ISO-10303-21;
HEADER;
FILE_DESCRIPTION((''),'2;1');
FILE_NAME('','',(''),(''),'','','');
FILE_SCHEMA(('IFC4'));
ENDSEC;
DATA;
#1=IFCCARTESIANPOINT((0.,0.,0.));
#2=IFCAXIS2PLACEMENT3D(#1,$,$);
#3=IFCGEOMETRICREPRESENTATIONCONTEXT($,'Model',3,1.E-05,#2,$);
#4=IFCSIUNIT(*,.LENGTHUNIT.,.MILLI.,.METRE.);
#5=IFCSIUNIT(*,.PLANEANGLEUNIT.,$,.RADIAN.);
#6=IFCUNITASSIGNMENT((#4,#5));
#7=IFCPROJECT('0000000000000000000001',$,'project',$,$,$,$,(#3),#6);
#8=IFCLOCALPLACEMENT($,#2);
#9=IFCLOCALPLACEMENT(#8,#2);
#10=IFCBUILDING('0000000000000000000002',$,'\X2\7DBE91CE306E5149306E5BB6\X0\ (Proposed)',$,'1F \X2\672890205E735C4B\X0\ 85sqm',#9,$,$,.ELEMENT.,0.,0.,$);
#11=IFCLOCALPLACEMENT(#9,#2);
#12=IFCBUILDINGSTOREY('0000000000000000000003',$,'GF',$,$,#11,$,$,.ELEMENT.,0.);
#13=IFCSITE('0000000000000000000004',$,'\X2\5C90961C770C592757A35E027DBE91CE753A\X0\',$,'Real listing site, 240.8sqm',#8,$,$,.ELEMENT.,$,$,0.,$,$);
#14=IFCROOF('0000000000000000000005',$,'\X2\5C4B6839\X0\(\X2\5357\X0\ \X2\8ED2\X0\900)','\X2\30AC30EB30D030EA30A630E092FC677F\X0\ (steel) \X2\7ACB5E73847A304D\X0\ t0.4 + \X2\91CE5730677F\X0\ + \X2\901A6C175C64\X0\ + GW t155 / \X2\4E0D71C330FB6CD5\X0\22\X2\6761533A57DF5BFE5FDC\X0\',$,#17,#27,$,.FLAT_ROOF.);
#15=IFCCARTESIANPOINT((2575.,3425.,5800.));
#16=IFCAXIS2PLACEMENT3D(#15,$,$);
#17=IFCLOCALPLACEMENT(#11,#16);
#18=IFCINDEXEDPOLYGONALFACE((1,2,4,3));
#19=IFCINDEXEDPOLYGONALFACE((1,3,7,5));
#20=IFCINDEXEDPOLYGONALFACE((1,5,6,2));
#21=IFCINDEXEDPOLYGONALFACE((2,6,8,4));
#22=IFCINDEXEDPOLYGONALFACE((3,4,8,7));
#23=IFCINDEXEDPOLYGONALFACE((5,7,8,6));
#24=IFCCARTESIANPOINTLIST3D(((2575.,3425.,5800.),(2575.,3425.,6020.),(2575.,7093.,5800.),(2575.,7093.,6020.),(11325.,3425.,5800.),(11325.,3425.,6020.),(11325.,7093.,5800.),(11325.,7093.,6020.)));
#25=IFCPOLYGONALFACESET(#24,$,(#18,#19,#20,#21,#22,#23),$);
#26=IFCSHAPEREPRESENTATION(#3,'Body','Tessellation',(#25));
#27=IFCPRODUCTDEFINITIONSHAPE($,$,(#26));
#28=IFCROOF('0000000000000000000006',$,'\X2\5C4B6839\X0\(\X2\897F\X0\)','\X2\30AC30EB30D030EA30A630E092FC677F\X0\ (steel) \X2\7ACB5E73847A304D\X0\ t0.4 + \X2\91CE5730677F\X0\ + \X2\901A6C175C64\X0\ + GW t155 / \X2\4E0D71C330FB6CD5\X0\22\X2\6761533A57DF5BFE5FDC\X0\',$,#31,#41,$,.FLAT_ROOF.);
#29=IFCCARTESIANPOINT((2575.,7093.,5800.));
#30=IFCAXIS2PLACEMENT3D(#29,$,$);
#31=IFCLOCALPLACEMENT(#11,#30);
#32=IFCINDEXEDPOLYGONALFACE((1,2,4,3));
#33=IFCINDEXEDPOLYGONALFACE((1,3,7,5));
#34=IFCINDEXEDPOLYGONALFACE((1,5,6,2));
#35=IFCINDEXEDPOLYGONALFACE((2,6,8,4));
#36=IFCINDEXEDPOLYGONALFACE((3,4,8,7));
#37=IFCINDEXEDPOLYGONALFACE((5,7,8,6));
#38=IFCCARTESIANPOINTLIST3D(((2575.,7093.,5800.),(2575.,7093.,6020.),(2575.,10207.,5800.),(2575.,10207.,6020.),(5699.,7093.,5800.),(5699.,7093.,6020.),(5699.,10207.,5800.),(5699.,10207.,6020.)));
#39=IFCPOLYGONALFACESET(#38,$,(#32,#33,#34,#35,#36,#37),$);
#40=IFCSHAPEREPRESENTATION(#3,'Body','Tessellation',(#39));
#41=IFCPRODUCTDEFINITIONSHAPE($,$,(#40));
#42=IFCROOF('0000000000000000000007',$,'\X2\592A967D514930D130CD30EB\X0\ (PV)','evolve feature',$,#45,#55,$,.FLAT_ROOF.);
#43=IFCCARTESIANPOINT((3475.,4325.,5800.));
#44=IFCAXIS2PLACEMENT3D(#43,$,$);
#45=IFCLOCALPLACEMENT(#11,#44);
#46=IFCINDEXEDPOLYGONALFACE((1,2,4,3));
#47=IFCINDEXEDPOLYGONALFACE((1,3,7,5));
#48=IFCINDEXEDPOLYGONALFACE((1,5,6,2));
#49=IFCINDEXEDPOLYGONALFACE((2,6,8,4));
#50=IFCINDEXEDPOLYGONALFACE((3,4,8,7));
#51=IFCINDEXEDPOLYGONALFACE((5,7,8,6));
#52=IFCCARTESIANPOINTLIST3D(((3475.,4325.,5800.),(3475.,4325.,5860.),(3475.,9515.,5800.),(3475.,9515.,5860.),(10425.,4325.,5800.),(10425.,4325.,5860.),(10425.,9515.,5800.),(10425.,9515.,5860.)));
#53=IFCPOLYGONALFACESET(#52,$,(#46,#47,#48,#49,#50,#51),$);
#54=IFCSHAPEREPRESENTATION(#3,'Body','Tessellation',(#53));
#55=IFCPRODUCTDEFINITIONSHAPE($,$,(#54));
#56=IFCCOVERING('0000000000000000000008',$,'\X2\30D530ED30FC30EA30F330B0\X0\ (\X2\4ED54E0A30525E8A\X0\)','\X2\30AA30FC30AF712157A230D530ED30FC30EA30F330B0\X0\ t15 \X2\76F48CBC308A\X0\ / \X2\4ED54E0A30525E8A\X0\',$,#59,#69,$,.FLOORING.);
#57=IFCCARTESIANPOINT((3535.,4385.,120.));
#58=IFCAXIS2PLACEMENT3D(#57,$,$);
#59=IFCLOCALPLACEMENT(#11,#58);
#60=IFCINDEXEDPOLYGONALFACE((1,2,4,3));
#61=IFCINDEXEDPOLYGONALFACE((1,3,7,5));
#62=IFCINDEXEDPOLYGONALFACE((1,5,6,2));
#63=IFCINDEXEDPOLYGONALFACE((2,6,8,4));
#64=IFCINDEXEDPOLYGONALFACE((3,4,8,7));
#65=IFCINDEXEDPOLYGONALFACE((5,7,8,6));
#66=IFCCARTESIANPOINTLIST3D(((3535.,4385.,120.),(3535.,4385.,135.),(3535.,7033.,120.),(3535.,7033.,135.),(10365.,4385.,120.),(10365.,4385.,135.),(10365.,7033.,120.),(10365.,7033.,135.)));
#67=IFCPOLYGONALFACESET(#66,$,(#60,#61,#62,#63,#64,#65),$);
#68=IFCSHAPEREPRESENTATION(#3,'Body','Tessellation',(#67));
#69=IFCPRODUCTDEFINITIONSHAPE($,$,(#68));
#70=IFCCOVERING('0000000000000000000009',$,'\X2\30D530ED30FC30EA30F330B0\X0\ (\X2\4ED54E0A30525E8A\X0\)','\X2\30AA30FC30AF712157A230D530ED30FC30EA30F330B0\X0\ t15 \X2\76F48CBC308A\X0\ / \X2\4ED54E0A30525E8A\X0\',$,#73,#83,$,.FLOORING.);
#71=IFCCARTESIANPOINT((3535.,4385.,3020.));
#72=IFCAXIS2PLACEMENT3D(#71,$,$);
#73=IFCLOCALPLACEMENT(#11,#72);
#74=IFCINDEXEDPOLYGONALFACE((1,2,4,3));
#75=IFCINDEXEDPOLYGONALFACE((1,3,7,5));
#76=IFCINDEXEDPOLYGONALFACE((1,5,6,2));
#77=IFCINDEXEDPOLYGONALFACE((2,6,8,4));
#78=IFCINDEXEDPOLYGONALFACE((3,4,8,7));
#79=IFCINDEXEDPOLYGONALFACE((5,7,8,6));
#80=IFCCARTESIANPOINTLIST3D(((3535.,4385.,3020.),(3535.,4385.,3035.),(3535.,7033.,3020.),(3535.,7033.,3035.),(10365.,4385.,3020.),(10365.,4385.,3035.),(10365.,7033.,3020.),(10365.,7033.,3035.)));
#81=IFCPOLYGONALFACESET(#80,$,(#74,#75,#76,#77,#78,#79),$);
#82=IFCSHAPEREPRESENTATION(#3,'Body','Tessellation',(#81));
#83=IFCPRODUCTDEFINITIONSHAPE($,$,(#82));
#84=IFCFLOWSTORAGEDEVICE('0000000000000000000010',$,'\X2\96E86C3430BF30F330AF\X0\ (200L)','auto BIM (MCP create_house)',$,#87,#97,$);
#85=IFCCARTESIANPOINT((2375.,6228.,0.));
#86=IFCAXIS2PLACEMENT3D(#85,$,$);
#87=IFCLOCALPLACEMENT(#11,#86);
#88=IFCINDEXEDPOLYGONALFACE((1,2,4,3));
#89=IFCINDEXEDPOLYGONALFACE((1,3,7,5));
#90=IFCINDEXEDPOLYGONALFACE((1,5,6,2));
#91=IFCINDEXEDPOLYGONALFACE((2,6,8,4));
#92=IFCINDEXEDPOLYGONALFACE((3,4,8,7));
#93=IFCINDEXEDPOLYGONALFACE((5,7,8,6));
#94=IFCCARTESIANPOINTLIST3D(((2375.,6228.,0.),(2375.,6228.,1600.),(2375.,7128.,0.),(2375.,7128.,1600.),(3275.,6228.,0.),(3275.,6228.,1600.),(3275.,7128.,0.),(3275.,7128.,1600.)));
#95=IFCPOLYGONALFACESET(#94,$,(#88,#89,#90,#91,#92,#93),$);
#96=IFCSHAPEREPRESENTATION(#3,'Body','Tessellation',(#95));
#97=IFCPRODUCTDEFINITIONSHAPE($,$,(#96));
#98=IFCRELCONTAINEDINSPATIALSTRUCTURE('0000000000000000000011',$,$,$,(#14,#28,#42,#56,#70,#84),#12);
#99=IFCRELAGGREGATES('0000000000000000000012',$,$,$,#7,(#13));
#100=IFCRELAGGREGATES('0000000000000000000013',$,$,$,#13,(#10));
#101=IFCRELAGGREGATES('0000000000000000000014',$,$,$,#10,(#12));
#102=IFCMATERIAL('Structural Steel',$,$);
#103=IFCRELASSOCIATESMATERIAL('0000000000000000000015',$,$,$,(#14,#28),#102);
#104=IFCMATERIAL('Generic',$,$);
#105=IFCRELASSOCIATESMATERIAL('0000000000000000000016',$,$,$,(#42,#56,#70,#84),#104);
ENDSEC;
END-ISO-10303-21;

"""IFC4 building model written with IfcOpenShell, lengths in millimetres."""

from ifc_helpers import new_model, si_unit, frame, frame_2d, origin, place, context, project, spatial, rectangle, extrude, material, element, save


model = new_model("IFC4")

# Units and contexts
model_context = context("Model", 3, precision=1e-05, world=origin())
ifc_project = project(units=[si_unit("LENGTHUNIT", "METRE", prefix="MILLI"), si_unit("PLANEANGLEUNIT", "RADIAN")], contexts=[model_context])

# Site, building, storey
site_placement = place(None, origin())
site = spatial("IfcSite", under=ifc_project, at=site_placement, Name="岐阜県大垣市綾野町", ObjectType="Real listing site, 240.8sqm", CompositionType="ELEMENT", RefElevation=0.0)
building_placement = place(site_placement, origin())
building = spatial("IfcBuilding", under=site, at=building_placement, Name="綾野の光の家 (Proposed)", ObjectType="1F 木造平屋 85sqm", CompositionType="ELEMENT", ElevationOfRefHeight=0.0, ElevationOfTerrain=0.0)
storey_placement = place(building_placement, origin())
storey = spatial("IfcBuildingStorey", under=building, at=storey_placement, Name="GF", CompositionType="ELEMENT", Elevation=0.0)

# Shared definitions
ifc_material_1 = material(Name="Generic")

# Roofs
ifc_material_2 = material(Name="Structural Steel")
roof_1_placement = place(storey_placement, frame((2575.0, 3425.0, 5800.0)))
element("IfcRoof", 1, at=roof_1_placement, inside=storey, material=ifc_material_2, Name="屋根(南 軒900)", Description="ガルバリウム鋼板 (steel) 立平葺き t0.4 + 野地板 + 通気層 + GW t155 / 不燃・法22条区域対応", PredefinedType="FLAT_ROOF", context=model_context, shape_type="SweptSolid", body=[
    extrude(rectangle(XDim=8750.0, YDim=3668.0, at=frame_2d((4375.0, 1834.0))), frame((2575.0, 3425.0, 5800.0)), (0.0, 0.0, 1.0), 220.0),
])
roof_2_placement = place(storey_placement, frame((2575.0, 7093.0, 5800.0)))
element("IfcRoof", 2, at=roof_2_placement, inside=storey, material=ifc_material_2, Name="屋根(西)", Description="ガルバリウム鋼板 (steel) 立平葺き t0.4 + 野地板 + 通気層 + GW t155 / 不燃・法22条区域対応", PredefinedType="FLAT_ROOF", context=model_context, shape_type="SweptSolid", body=[
    extrude(rectangle(XDim=3124.0, YDim=3114.0, at=frame_2d((1562.0, 1557.0))), frame((2575.0, 7093.0, 5800.0)), (0.0, 0.0, 1.0), 220.0),
])
roof_3_placement = place(storey_placement, frame((3475.0, 4325.0, 5800.0)))
element("IfcRoof", 3, at=roof_3_placement, inside=storey, material=ifc_material_1, Name="太陽光パネル (PV)", Description="evolve feature", PredefinedType="FLAT_ROOF", context=model_context, shape_type="SweptSolid", body=[
    extrude(rectangle(XDim=6950.0, YDim=5190.0, at=frame_2d((3475.0, 2595.0))), frame((3475.0, 4325.0, 5800.0)), (0.0, 0.0, 1.0), 60.0),
])

# Coverings
covering_1_placement = place(storey_placement, frame((3535.0, 4385.0, 120.0)))
element("IfcCovering", 4, at=covering_1_placement, inside=storey, material=ifc_material_1, Name="フローリング (仕上げ床)", Description="オーク無垢フローリング t15 直貼り / 仕上げ床", PredefinedType="FLOORING", context=model_context, shape_type="SweptSolid", body=[
    extrude(rectangle(XDim=6830.0, YDim=2648.0, at=frame_2d((3415.0, 1324.0))), frame((3535.0, 4385.0, 120.0)), (0.0, 0.0, 1.0), 15.0),
])
covering_2_placement = place(storey_placement, frame((3535.0, 4385.0, 3020.0)))
element("IfcCovering", 5, at=covering_2_placement, inside=storey, material=ifc_material_1, Name="フローリング (仕上げ床)", Description="オーク無垢フローリング t15 直貼り / 仕上げ床", PredefinedType="FLOORING", context=model_context, shape_type="SweptSolid", body=[
    extrude(rectangle(XDim=6830.0, YDim=2648.0, at=frame_2d((3415.0, 1324.0))), frame((3535.0, 4385.0, 3020.0)), (0.0, 0.0, 1.0), 15.0),
])

# Flow storage device
flow_storage_device_placement = place(storey_placement, frame((2375.0, 6228.0, 0.0)))
element("IfcFlowStorageDevice", 6, at=flow_storage_device_placement, inside=storey, material=ifc_material_1, Name="雨水タンク (200L)", Description="auto BIM (MCP create_house)", context=model_context, shape_type="SweptSolid", body=[
    extrude(rectangle(XDim=900.0, YDim=900.0, at=frame_2d((450.0, 450.0))), frame((2375.0, 6228.0, 0.0)), (0.0, 0.0, 1.0), 1600.0),
])

save(model, "model.ifc")
